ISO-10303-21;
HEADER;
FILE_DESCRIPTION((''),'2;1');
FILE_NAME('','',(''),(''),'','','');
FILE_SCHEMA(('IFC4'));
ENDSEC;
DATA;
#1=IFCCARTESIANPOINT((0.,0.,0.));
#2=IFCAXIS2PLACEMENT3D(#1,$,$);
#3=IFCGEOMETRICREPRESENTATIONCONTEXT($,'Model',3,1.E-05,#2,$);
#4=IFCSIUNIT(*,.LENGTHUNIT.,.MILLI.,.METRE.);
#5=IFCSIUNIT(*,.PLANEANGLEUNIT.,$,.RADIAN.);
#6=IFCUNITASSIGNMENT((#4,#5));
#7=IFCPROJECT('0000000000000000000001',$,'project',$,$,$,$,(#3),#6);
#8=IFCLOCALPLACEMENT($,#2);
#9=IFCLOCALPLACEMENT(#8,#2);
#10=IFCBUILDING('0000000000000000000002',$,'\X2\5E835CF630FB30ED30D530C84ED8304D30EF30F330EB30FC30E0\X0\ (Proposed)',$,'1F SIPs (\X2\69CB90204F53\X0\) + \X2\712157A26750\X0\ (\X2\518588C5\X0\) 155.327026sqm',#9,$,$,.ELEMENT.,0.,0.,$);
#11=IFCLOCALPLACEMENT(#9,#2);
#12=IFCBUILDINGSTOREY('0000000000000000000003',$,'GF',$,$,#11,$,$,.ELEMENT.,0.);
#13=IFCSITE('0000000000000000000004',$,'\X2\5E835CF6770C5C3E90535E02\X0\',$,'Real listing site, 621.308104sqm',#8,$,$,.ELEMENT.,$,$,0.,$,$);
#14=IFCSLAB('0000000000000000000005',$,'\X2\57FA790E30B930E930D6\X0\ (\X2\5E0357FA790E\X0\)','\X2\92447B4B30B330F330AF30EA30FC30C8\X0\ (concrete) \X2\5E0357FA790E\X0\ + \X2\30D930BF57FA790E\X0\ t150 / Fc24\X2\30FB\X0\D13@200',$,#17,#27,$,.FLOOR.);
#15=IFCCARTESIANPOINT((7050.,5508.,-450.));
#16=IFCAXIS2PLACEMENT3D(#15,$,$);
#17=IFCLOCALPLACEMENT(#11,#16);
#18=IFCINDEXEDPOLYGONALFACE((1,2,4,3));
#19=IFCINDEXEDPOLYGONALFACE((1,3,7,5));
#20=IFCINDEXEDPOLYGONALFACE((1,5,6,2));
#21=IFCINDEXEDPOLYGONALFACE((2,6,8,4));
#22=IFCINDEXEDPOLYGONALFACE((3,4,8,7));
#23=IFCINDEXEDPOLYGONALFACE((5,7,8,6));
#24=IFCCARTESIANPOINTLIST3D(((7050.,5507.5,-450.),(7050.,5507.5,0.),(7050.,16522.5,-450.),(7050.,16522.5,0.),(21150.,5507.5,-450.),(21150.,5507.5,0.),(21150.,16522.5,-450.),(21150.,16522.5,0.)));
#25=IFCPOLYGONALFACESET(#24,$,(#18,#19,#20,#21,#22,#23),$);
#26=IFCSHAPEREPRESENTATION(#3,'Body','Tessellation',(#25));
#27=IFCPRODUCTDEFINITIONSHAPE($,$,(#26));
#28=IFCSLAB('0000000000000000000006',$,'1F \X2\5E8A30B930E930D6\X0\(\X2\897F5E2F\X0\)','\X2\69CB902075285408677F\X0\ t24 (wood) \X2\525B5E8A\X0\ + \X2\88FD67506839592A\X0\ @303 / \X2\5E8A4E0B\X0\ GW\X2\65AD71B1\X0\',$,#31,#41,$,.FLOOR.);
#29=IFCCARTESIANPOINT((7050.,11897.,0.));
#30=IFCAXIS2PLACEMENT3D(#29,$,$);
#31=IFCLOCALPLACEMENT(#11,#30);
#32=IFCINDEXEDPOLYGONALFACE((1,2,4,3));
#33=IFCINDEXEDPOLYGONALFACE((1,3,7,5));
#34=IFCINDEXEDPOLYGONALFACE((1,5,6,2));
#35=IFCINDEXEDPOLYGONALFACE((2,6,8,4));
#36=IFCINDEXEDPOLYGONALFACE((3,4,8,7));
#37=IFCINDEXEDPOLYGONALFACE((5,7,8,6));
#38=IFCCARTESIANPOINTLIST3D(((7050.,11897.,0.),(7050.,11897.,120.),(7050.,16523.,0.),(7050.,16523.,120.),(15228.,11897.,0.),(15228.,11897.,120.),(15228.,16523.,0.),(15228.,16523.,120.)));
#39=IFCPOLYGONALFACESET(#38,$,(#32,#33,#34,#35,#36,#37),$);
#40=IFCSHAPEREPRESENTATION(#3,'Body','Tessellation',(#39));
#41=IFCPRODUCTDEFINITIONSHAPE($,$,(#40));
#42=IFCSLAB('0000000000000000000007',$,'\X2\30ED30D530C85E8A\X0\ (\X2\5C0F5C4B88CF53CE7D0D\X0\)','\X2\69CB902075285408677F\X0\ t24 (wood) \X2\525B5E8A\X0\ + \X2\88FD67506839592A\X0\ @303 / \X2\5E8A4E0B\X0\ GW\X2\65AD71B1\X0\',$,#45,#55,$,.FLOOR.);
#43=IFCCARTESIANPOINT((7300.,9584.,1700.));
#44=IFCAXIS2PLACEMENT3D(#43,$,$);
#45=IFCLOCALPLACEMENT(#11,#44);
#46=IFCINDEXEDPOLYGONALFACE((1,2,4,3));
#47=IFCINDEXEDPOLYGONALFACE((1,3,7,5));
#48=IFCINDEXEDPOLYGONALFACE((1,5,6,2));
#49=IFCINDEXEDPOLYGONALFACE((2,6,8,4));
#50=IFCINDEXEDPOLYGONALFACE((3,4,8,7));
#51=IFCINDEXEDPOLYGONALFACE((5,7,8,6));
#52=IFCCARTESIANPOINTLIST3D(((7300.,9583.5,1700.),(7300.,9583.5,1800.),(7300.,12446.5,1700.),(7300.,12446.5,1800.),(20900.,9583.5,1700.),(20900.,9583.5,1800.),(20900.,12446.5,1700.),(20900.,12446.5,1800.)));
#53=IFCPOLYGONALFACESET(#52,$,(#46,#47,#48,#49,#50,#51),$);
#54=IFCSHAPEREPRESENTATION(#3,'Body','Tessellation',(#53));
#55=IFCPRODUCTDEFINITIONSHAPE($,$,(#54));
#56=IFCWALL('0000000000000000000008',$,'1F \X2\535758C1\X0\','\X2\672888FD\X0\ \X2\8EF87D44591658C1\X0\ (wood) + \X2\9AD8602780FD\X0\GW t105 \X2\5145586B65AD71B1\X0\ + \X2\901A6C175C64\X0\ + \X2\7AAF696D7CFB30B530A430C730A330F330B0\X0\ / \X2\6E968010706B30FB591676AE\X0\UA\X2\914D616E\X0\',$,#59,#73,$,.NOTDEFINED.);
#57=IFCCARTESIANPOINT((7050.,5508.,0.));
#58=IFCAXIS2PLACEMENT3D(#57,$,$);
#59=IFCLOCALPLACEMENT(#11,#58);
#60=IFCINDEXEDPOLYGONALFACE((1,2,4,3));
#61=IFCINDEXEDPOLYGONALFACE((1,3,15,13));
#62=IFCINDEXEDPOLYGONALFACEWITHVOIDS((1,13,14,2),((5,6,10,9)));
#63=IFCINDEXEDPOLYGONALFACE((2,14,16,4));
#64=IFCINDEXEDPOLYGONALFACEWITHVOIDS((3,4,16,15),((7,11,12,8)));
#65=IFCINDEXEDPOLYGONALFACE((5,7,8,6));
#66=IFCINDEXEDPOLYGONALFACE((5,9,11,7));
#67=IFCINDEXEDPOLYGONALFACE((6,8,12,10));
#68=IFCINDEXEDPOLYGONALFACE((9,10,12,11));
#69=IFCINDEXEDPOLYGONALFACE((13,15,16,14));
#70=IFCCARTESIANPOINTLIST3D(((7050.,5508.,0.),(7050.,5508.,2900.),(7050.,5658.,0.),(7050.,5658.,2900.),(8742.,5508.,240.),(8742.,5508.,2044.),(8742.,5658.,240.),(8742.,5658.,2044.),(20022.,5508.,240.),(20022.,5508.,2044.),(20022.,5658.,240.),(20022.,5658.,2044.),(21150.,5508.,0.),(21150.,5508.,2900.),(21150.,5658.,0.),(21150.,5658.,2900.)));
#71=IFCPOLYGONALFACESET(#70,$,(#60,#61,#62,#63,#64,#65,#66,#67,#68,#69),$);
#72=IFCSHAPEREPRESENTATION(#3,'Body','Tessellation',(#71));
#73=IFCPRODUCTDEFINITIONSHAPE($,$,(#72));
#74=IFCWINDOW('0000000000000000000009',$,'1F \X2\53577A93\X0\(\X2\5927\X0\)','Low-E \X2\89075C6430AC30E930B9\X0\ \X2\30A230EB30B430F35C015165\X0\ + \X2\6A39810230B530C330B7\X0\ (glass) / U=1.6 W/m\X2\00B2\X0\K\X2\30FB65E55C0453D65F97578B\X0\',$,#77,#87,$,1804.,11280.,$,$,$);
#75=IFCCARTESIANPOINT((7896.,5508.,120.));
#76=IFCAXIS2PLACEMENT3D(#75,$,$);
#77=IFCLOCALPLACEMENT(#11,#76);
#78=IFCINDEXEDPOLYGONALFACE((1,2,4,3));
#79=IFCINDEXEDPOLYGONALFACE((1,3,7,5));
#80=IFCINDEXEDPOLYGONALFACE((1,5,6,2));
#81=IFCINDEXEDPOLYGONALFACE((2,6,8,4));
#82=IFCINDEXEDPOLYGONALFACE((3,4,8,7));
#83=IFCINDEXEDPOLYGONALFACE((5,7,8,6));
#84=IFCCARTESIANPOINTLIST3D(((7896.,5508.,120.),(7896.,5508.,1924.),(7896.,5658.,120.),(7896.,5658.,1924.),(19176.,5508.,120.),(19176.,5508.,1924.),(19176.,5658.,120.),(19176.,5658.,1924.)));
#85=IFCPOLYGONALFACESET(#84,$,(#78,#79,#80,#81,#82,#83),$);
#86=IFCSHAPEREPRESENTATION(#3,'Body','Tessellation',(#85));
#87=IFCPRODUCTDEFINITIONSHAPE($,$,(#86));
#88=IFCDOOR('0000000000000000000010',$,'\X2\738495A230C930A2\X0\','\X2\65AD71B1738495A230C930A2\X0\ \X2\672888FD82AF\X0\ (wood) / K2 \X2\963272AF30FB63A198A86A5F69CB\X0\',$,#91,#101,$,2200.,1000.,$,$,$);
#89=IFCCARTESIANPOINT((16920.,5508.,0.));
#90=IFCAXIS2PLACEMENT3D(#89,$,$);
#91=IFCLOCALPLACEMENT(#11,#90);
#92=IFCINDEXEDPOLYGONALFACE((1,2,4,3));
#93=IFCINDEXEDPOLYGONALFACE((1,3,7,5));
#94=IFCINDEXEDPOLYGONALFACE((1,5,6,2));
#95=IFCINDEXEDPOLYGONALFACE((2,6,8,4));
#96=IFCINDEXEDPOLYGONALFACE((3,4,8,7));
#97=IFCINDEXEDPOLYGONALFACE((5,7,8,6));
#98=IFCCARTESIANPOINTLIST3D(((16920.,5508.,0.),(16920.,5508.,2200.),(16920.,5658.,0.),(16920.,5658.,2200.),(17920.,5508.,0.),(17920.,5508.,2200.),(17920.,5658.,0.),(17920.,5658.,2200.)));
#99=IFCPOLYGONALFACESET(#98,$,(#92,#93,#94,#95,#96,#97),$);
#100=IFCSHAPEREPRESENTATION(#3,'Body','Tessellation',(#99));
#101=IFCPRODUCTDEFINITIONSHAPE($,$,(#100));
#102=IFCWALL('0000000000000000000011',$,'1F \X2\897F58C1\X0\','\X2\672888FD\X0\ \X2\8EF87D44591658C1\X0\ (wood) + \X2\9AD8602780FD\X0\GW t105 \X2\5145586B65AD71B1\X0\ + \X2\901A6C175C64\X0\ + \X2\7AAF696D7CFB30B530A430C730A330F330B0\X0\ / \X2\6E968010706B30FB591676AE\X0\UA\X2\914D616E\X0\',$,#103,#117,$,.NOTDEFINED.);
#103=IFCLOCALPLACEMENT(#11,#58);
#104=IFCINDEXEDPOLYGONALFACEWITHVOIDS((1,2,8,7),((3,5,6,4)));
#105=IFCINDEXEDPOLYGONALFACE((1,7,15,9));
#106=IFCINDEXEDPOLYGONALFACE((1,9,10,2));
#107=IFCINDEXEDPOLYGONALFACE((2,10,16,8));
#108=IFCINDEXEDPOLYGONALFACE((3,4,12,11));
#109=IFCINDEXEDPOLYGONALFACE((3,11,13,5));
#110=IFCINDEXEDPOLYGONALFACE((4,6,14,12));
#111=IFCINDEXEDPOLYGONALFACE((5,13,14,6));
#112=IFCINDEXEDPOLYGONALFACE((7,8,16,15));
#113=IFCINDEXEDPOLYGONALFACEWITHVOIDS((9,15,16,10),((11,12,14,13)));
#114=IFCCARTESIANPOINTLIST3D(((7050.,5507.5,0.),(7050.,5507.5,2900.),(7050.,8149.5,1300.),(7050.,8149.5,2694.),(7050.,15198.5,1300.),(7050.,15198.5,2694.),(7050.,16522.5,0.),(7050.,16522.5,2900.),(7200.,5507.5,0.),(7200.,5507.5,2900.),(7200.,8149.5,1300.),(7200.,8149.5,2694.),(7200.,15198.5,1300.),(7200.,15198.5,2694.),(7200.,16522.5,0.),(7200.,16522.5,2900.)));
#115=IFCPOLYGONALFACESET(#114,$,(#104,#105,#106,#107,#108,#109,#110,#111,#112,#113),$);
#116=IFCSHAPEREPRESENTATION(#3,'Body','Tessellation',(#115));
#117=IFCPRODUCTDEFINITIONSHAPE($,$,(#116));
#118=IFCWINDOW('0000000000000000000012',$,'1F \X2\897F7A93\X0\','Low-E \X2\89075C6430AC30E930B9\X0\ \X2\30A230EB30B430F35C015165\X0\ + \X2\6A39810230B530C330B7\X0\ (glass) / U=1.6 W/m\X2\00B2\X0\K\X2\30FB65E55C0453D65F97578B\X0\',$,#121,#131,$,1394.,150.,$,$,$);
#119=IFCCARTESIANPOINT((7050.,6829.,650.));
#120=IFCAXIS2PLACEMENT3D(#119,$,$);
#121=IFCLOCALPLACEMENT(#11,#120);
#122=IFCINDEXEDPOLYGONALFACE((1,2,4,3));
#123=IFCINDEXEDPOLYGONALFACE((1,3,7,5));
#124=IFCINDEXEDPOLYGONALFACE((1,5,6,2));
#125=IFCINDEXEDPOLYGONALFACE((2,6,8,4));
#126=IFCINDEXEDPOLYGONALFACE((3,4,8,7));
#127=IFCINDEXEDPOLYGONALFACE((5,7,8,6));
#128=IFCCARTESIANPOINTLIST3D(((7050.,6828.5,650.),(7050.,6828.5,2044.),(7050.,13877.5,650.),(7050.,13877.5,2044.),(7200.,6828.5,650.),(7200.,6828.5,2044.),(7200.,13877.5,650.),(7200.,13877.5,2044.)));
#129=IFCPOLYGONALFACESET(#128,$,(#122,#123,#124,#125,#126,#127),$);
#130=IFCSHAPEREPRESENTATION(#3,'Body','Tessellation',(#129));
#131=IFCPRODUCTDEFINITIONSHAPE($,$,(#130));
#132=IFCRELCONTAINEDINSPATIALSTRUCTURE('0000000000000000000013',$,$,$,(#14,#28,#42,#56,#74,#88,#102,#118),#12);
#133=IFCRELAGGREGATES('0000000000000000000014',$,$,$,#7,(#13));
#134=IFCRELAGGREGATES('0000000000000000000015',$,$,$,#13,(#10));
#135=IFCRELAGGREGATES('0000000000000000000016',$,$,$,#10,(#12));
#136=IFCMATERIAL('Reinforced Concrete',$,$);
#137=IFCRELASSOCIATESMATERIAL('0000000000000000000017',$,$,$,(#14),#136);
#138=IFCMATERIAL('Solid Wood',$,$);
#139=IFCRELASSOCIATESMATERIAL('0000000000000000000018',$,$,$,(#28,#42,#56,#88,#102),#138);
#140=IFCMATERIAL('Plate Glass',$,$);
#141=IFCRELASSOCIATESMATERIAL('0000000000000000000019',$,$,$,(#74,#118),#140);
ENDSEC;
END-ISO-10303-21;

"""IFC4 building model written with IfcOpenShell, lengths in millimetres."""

from ifc_helpers import new_model, si_unit, frame, frame_2d, origin, place, context, project, spatial, rectangle, extrude, material, element, fill, save


model = new_model("IFC4")

# Units and contexts
model_context = context("Model", 3, precision=1e-05, world=origin())
ifc_project = project(units=[si_unit("LENGTHUNIT", "METRE", prefix="MILLI"), si_unit("PLANEANGLEUNIT", "RADIAN")], contexts=[model_context])

# Site, building, storey
site_placement = place(None, origin())
site = spatial("IfcSite", under=ifc_project, at=site_placement, Name="広島県尾道市", ObjectType="Real listing site, 621.308104sqm", CompositionType="ELEMENT", RefElevation=0.0)
building_placement = place(site_placement, origin())
building = spatial("IfcBuilding", under=site, at=building_placement, Name="広島・ロフト付きワンルーム (Proposed)", ObjectType="1F SIPs (構造体) + 無垢材 (内装) 155.327026sqm", CompositionType="ELEMENT", ElevationOfRefHeight=0.0, ElevationOfTerrain=0.0)
storey_placement = place(building_placement, origin())
storey = spatial("IfcBuildingStorey", under=building, at=storey_placement, Name="GF", CompositionType="ELEMENT", Elevation=0.0)

# Slabs
ifc_material_1 = material(Name="Reinforced Concrete")
slab_1_placement = place(storey_placement, frame((7050.0, 5508.0, -450.0)))
element("IfcSlab", 1, at=slab_1_placement, inside=storey, material=ifc_material_1, Name="基礎スラブ (布基礎)", Description="鉄筋コンクリート (concrete) 布基礎 + ベタ基礎 t150 / Fc24・D13@200", PredefinedType="FLOOR", context=model_context, shape_type="SweptSolid", body=[
    extrude(rectangle(XDim=14100.0, YDim=11015.0, at=frame_2d((7050.0, 5507.0))), frame((7050.0, 5508.0, -450.0)), (0.0, 0.0, 1.0), 450.0),
])
ifc_material_2 = material(Name="Solid Wood")
slab_2_placement = place(storey_placement, frame((7050.0, 11897.0, 0.0)))
element("IfcSlab", 2, at=slab_2_placement, inside=storey, material=ifc_material_2, Name="1F 床スラブ(西帯)", Description="構造用合板 t24 (wood) 剛床 + 製材根太 @303 / 床下 GW断熱", PredefinedType="FLOOR", context=model_context, shape_type="SweptSolid", body=[
    extrude(rectangle(XDim=8178.0, YDim=4626.0, at=frame_2d((4089.0, 2313.0))), frame((7050.0, 11897.0, 0.0)), (0.0, 0.0, 1.0), 120.0),
])
slab_3_placement = place(storey_placement, frame((7300.0, 9584.0, 1700.0)))
element("IfcSlab", 3, at=slab_3_placement, inside=storey, material=ifc_material_2, Name="ロフト床 (小屋裏収納)", Description="構造用合板 t24 (wood) 剛床 + 製材根太 @303 / 床下 GW断熱", PredefinedType="FLOOR", context=model_context, shape_type="SweptSolid", body=[
    extrude(rectangle(XDim=13600.0, YDim=2863.0, at=frame_2d((6800.0, 1431.0))), frame((7300.0, 9584.0, 1700.0)), (0.0, 0.0, 1.0), 100.0),
])

# Wall, openings, window, door
wall_1_placement = place(storey_placement, frame((7050.0, 5508.0, 0.0)))
wall_1 = element("IfcWall", 4, at=wall_1_placement, inside=storey, material=ifc_material_2, Name="1F 南壁", Description="木製 軸組外壁 (wood) + 高性能GW t105 充填断熱 + 通気層 + 窯業系サイディング / 準耐火・外皮UA配慮", PredefinedType="NOTDEFINED", context=model_context, shape_type="SweptSolid", body=[
    extrude(rectangle(XDim=14100.0, YDim=150.0, at=frame_2d((7050.0, 75.0))), frame((7050.0, 5508.0, 0.0)), (0.0, 0.0, 1.0), 2900.0),
])
opening_1_placement = place(storey_placement, frame((7896.0, 5508.0, 120.0)))
opening_1 = element("IfcOpeningElement", 5, at=opening_1_placement, cuts=wall_1, PredefinedType="NOTDEFINED", context=model_context, shape_type="SweptSolid", body=[
    extrude(rectangle(XDim=11280.0, YDim=150.0, at=frame_2d((5640.0, 75.0))), frame((7896.0, 5508.0, 120.0)), (0.0, 0.0, 1.0), 1804.0),
])
opening_2_placement = place(storey_placement, frame((16920.0, 5508.0, 0.0)))
opening_2 = element("IfcOpeningElement", 6, at=opening_2_placement, cuts=wall_1, PredefinedType="NOTDEFINED", context=model_context, shape_type="SweptSolid", body=[
    extrude(rectangle(XDim=1000.0, YDim=150.0, at=frame_2d((500.0, 75.0))), frame((16920.0, 5508.0, 0.0)), (0.0, 0.0, 1.0), 2200.0),
])
ifc_material_3 = material(Name="Plate Glass")
window_1_placement = place(storey_placement, frame((7896.0, 5508.0, 120.0)))
window_1 = element("IfcWindow", 7, at=window_1_placement, inside=storey, material=ifc_material_3, Name="1F 南窓(大)", Description="Low-E 複層ガラス アルゴン封入 + 樹脂サッシ (glass) / U=1.6 W/m²K・日射取得型", OverallHeight=1804.0, OverallWidth=11280.0, context=model_context, shape_type="SweptSolid", body=[
    extrude(rectangle(XDim=11280.0, YDim=150.0, at=frame_2d((5640.0, 75.0))), frame((7896.0, 5508.0, 120.0)), (0.0, 0.0, 1.0), 1804.0),
])
fill(opening_1, window_1)
door_1_placement = place(storey_placement, frame((16920.0, 5508.0, 0.0)))
door_1 = element("IfcDoor", 8, at=door_1_placement, inside=storey, material=ifc_material_2, Name="玄関ドア", Description="断熱玄関ドア 木製芯 (wood) / K2 防犯・採風機構", OverallHeight=2200.0, OverallWidth=1000.0, context=model_context, shape_type="SweptSolid", body=[
    extrude(rectangle(XDim=1000.0, YDim=150.0, at=frame_2d((500.0, 75.0))), frame((16920.0, 5508.0, 0.0)), (0.0, 0.0, 1.0), 2200.0),
])
fill(opening_2, door_1)

# Wall, opening, window
wall_2_placement = place(storey_placement, frame((7050.0, 5508.0, 0.0)))
wall_2 = element("IfcWall", 9, at=wall_2_placement, inside=storey, material=ifc_material_2, Name="1F 西壁", Description="木製 軸組外壁 (wood) + 高性能GW t105 充填断熱 + 通気層 + 窯業系サイディング / 準耐火・外皮UA配慮", PredefinedType="NOTDEFINED", context=model_context, shape_type="SweptSolid", body=[
    extrude(rectangle(XDim=150.0, YDim=11015.0, at=frame_2d((75.0, 5507.0))), frame((7050.0, 5508.0, 0.0)), (0.0, 0.0, 1.0), 2900.0),
])
opening_3_placement = place(storey_placement, frame((7050.0, 6829.0, 650.0)))
opening_3 = element("IfcOpeningElement", 10, at=opening_3_placement, cuts=wall_2, PredefinedType="NOTDEFINED", context=model_context, shape_type="SweptSolid", body=[
    extrude(rectangle(XDim=150.0, YDim=7049.0, at=frame_2d((75.0, 3524.0))), frame((7050.0, 6829.0, 650.0)), (0.0, 0.0, 1.0), 1394.0),
])
window_2_placement = place(storey_placement, frame((7050.0, 6829.0, 650.0)))
window_2 = element("IfcWindow", 11, at=window_2_placement, inside=storey, material=ifc_material_3, Name="1F 西窓", Description="Low-E 複層ガラス アルゴン封入 + 樹脂サッシ (glass) / U=1.6 W/m²K・日射取得型", OverallHeight=1394.0, OverallWidth=150.0, context=model_context, shape_type="SweptSolid", body=[
    extrude(rectangle(XDim=150.0, YDim=7049.0, at=frame_2d((75.0, 3524.0))), frame((7050.0, 6829.0, 650.0)), (0.0, 0.0, 1.0), 1394.0),
])
fill(opening_3, window_2)

save(model, "model.ifc")
